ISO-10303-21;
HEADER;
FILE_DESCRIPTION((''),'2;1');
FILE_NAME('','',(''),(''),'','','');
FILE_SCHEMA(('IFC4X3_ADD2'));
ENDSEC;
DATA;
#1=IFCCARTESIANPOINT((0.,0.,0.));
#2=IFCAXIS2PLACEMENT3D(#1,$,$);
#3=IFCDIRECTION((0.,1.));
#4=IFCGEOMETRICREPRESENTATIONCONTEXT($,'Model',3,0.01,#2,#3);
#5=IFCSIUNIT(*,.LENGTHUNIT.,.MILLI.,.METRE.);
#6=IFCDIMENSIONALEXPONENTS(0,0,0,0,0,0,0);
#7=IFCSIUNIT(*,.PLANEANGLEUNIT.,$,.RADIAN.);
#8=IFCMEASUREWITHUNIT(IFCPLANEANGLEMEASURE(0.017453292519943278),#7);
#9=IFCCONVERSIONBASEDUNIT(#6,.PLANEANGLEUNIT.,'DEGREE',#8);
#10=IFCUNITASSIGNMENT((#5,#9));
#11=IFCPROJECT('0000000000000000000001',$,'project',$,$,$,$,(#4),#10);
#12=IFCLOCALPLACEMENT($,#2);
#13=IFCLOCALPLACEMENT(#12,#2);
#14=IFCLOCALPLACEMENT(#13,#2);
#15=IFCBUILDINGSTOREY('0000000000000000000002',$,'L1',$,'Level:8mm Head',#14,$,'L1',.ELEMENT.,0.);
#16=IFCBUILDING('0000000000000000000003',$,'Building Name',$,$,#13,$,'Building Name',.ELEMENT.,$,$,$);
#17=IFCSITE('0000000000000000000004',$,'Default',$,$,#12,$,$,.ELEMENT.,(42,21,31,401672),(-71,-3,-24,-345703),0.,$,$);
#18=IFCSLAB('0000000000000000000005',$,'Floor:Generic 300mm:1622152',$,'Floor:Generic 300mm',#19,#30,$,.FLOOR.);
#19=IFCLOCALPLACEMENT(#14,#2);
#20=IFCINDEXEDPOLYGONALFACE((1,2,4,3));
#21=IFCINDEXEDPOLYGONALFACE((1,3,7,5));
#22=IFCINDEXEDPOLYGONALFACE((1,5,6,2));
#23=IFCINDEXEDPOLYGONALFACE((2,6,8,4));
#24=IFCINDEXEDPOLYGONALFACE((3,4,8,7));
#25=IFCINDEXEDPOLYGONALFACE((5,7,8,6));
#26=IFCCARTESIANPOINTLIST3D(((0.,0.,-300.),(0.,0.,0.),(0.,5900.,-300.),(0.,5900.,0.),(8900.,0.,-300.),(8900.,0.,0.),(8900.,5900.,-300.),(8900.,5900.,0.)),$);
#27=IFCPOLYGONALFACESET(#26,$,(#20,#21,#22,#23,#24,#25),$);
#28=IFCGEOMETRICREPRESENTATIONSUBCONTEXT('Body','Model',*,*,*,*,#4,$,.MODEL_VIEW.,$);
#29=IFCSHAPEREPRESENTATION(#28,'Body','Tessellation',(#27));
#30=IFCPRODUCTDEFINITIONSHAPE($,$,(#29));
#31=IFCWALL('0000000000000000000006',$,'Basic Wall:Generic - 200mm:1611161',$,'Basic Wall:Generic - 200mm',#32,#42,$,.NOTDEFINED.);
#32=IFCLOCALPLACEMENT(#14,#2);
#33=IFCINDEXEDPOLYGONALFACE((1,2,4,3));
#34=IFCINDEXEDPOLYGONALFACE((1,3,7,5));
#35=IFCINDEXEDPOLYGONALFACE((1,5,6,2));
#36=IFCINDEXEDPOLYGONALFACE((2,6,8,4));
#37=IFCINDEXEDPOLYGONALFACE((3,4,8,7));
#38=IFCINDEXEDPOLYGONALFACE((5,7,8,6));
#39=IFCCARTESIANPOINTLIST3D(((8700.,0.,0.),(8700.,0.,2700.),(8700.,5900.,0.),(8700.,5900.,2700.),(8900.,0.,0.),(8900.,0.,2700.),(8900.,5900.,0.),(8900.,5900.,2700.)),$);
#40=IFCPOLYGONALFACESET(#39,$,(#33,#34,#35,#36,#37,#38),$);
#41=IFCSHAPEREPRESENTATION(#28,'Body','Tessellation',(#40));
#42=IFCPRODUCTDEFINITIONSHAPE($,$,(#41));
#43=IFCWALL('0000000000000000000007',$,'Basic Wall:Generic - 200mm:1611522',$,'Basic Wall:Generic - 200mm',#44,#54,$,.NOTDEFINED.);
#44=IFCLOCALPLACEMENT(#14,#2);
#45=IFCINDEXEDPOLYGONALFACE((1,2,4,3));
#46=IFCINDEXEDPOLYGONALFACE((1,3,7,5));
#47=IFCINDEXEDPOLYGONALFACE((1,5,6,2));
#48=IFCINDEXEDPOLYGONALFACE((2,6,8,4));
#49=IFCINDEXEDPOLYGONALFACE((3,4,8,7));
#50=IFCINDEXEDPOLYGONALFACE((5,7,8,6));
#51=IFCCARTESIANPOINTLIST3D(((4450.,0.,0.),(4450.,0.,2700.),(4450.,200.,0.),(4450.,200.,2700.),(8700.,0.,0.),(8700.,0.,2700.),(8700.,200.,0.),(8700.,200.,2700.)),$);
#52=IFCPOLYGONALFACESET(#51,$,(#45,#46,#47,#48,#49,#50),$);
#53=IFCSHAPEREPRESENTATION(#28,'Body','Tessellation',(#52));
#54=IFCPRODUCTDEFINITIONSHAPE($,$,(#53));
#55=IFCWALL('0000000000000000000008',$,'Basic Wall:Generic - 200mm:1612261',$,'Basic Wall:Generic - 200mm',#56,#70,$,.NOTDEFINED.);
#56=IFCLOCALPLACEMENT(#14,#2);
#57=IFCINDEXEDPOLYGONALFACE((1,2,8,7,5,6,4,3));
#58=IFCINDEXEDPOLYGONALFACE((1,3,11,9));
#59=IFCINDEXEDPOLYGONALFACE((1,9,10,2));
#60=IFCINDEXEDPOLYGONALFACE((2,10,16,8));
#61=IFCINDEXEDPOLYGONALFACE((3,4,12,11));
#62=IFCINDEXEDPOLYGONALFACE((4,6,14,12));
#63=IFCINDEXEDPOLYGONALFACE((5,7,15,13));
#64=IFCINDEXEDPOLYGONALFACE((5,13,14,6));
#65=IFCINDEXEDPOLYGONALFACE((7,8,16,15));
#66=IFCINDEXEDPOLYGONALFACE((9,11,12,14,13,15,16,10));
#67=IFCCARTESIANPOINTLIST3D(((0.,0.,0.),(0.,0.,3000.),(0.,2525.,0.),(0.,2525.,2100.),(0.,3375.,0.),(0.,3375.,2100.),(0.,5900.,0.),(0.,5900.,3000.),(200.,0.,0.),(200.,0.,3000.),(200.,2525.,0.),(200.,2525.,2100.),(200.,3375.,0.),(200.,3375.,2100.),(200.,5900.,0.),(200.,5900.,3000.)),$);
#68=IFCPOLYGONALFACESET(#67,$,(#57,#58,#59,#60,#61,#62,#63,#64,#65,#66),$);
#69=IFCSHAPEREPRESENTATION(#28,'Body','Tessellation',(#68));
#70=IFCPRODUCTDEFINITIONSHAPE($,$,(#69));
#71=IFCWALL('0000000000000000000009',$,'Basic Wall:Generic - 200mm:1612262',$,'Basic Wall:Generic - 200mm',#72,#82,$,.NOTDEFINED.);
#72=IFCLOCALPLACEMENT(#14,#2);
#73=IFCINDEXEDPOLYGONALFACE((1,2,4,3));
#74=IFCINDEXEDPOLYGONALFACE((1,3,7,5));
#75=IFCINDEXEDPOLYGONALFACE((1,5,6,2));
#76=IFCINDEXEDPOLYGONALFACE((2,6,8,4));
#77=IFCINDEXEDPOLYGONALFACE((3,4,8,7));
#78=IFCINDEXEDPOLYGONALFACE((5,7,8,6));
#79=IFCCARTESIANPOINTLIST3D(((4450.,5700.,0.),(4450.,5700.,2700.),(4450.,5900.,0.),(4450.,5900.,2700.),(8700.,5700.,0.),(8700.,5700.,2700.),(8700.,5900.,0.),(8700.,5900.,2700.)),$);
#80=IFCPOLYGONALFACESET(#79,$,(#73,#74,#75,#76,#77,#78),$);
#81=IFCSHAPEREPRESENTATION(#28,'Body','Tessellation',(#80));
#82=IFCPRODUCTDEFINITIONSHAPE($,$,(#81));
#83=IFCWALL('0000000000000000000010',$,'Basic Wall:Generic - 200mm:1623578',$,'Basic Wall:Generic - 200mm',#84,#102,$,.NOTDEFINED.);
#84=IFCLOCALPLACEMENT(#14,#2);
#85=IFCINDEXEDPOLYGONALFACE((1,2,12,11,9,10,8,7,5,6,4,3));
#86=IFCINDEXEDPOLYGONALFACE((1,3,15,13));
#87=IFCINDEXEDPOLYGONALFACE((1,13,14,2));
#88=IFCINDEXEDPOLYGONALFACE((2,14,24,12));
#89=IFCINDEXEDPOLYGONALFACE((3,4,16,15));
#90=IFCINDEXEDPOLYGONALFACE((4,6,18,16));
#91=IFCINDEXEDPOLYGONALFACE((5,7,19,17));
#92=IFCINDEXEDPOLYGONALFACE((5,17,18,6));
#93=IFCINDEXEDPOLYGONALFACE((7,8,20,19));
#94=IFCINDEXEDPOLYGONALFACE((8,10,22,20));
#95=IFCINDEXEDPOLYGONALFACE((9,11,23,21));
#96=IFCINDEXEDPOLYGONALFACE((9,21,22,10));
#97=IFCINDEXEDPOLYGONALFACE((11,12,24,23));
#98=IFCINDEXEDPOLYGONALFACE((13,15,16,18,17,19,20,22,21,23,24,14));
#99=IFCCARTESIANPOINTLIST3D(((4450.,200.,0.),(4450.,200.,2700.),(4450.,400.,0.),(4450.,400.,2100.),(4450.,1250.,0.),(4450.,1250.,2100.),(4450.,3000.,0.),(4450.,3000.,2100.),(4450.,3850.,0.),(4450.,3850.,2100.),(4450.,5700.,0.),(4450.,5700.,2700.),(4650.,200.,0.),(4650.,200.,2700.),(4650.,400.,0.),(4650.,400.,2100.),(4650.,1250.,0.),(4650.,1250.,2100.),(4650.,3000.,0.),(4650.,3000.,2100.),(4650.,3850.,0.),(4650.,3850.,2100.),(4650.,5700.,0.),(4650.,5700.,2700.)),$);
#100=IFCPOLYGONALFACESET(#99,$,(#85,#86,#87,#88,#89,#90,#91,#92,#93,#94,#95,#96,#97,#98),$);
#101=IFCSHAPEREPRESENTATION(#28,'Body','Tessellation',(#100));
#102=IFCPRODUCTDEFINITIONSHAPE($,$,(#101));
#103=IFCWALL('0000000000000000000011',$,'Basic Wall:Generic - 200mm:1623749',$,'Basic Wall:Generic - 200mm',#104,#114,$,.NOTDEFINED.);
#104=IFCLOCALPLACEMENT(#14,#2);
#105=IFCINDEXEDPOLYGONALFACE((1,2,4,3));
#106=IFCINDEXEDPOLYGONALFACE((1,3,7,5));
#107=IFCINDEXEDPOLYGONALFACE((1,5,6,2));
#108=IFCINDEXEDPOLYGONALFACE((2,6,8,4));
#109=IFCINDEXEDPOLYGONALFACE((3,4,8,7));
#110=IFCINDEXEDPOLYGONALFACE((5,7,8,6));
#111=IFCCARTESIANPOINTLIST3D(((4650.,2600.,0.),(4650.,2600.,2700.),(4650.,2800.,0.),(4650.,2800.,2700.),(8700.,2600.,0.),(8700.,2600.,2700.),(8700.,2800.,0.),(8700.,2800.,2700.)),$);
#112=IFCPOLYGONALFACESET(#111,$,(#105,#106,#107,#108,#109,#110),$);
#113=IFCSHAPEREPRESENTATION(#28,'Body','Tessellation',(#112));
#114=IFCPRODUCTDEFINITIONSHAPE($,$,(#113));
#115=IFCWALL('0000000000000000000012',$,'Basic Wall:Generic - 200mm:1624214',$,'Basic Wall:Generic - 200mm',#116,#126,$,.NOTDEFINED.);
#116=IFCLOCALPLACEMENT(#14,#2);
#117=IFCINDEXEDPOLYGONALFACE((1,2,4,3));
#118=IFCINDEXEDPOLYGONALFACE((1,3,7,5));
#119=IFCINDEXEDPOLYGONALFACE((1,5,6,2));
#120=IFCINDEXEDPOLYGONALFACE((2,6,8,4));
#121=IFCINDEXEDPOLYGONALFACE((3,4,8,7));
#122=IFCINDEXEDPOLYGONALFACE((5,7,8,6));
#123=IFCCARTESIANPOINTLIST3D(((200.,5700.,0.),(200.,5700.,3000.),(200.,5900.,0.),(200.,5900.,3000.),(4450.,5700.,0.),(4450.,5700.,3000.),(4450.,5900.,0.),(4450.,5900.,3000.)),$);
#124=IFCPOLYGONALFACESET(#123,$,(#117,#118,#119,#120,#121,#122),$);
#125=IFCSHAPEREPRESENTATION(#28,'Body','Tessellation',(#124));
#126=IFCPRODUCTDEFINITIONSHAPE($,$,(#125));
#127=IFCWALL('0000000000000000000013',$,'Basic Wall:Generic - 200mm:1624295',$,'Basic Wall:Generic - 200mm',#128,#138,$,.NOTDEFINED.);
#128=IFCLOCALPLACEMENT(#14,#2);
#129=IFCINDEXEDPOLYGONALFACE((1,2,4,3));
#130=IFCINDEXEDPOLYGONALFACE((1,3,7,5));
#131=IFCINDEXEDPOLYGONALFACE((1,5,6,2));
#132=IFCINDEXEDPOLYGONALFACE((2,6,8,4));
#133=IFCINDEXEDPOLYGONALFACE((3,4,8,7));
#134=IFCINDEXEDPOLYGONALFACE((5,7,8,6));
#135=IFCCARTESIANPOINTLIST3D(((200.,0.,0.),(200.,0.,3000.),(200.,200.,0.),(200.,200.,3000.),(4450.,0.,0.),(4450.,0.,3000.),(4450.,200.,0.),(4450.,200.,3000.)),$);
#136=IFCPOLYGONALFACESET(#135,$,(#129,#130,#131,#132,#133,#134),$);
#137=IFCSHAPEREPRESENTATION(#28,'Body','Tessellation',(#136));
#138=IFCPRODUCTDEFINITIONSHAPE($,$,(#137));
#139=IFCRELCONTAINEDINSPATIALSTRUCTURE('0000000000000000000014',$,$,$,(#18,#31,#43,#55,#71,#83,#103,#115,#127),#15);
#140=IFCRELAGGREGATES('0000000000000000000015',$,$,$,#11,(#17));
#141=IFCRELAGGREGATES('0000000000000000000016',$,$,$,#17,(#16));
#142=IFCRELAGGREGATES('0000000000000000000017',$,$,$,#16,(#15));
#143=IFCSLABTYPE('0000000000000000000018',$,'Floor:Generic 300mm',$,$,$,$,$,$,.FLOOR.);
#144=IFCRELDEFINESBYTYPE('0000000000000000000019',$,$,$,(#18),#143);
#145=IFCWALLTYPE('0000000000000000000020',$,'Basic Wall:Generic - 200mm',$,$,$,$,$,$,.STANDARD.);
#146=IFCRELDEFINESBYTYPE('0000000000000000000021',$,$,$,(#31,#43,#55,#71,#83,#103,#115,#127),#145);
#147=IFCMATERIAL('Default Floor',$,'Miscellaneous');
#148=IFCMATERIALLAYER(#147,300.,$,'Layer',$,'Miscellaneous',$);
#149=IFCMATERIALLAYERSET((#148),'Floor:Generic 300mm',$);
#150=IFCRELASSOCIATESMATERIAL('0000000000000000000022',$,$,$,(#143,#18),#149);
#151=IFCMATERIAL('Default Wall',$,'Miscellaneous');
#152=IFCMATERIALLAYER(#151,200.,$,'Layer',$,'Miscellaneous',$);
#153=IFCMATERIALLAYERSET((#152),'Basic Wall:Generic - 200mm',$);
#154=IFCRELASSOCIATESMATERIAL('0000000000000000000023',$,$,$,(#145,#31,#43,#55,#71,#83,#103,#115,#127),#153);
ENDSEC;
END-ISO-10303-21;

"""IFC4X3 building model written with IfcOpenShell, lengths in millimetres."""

from ifc_helpers import new_model, entity, si_unit, converted_unit, direction, frame, frame_2d, origin, origin_2d_with_axis, place, context, subcontext, project, spatial, polyline, rectangle, extrude, clip, bounded_halfspace, material, layer, layer_set, layer_usage, type_object, element, save


model = new_model("IFC4X3")

# Units and contexts
model_context = context("Model", 3, precision=0.01, world=origin(), true_north=direction((0.0, 1.0)))
body_context = subcontext(model_context, "Body", "Model", "MODEL_VIEW")
ifc_project = project(units=[si_unit("LENGTHUNIT", "METRE", prefix="MILLI"), converted_unit("PLANEANGLEUNIT", "DEGREE", entity("IfcPlaneAngleMeasure", 0.017453292519943278), si_unit("PLANEANGLEUNIT", "RADIAN"), dimensions=[0, 0, 0, 0, 0, 0, 0])], contexts=[model_context])

# Site, building, storey
site_placement = place(None, origin())
site = spatial("IfcSite", under=ifc_project, at=site_placement, Name="Default", CompositionType="ELEMENT", RefLatitude=(42, 21, 31, 401672), RefLongitude=(-71, -3, -24, -345703), RefElevation=0.0)
building_placement = place(site_placement, origin())
building = spatial("IfcBuilding", under=site, at=building_placement, Name="Building Name", LongName="Building Name", CompositionType="ELEMENT")
storey_placement = place(building_placement, origin())
storey = spatial("IfcBuildingStorey", under=building, at=storey_placement, Name="L1", ObjectType="Level:8mm Head", LongName="L1", CompositionType="ELEMENT", Elevation=0.0)

# Slab
ifc_material_1 = material(Name="Default Floor", Category="Miscellaneous")
ifc_layer_1 = layer(ifc_material_1, 300.0, Name="Layer", Category="Miscellaneous")
ifc_layer_set_1 = layer_set([ifc_layer_1], Name="Floor:Generic 300mm")
ifc_layer_usage = layer_usage(ifc_layer_set_1, "AXIS3", "POSITIVE", 0.0)
slab_type = type_object("IfcSlabType", Name="Floor:Generic 300mm", PredefinedType="FLOOR", material=ifc_layer_set_1)
slab_placement = place(storey_placement, origin())
element("IfcSlab", 1, at=slab_placement, inside=storey, type_object=slab_type, material=ifc_layer_usage, Name="Floor:Generic 300mm:1622152", ObjectType="Floor:Generic 300mm", PredefinedType="FLOOR", context=body_context, shape_type="SweptSolid", body=[
    extrude(rectangle(XDim=5900.0, YDim=8900.0, at=origin_2d_with_axis()), frame((4450.0, 2950.0, 0.0), z_axis=(0.0, 0.0, -1.0), x_axis=(0.0, 1.0, 0.0)), (0.0, 0.0, 1.0), 300.0),
])

# Walls
ifc_material_2 = material(Name="Default Wall", Category="Miscellaneous")
ifc_layer_2 = layer(ifc_material_2, 200.0, Name="Layer", Category="Miscellaneous")
ifc_layer_set_2 = layer_set([ifc_layer_2], Name="Basic Wall:Generic - 200mm")
wall_type = type_object("IfcWallType", Name="Basic Wall:Generic - 200mm", PredefinedType="STANDARD", material=ifc_layer_set_2)
wall_1_placement = place(storey_placement, frame((8800.0, 0.0, 0.0), z_axis=(0.0, 0.0, 1.0), x_axis=(0.0, 1.0, 0.0)))
element("IfcWall", 2, at=wall_1_placement, inside=storey, type_object=wall_type, material=ifc_layer_set_2, Name="Basic Wall:Generic - 200mm:1611161", ObjectType="Basic Wall:Generic - 200mm", PredefinedType="NOTDEFINED", context=body_context, shape_type="Clipping", body=[
    clip(extrude(rectangle(XDim=5900.0, YDim=200.0, at=frame_2d((2950.0, 0.0), x_axis=(-1.0, 0.0))), origin(), (0.0, 0.0, 1.0), 2700.0), bounded_halfspace(frame((0.0, -100.0, 2700.0), z_axis=(0.0, 0.0, -1.0), x_axis=(0.0, 1.0, 0.0)), True, frame((0.0, -100.0, 2700.0)), polyline([(0.0, 0.0), (5900.0, 0.0), (5900.0, 200.0), (5700.0, 200.0), (2800.0, 200.0), (2600.0, 200.0), (200.0, 200.0), (0.0, 200.0), (0.0, 0.0)]))),
])
wall_2_placement = place(storey_placement, frame((4450.0, 100.0, 0.0)))
element("IfcWall", 3, at=wall_2_placement, inside=storey, type_object=wall_type, material=ifc_layer_set_2, Name="Basic Wall:Generic - 200mm:1611522", ObjectType="Basic Wall:Generic - 200mm", PredefinedType="NOTDEFINED", context=body_context, shape_type="Clipping", body=[
    clip(extrude(rectangle(XDim=4250.0, YDim=200.0, at=frame_2d((2125.0, 0.0), x_axis=(-1.0, 0.0))), origin(), (0.0, 0.0, 1.0), 2700.0), bounded_halfspace(frame((0.0, -100.0, 2700.0), z_axis=(0.0, 0.0, -1.0), x_axis=(-1.0, 0.0, 0.0)), True, frame((0.0, -100.0, 2700.0)), polyline([(0.0, 0.0), (4250.0, 0.0), (4250.0, 200.0), (200.0, 200.0), (0.0, 200.0), (0.0, 0.0)]))),
])

# Wall, opening
wall_3_placement = place(storey_placement, frame((100.0, 5900.0, 0.0), z_axis=(0.0, 0.0, 1.0), x_axis=(0.0, -1.0, 0.0)))
wall_3 = element("IfcWall", 4, at=wall_3_placement, inside=storey, type_object=wall_type, material=ifc_layer_set_2, Name="Basic Wall:Generic - 200mm:1612261", ObjectType="Basic Wall:Generic - 200mm", PredefinedType="NOTDEFINED", context=body_context, shape_type="SweptSolid", body=[
    extrude(rectangle(XDim=5900.0, YDim=200.0, at=frame_2d((2950.0, 0.0), x_axis=(-1.0, 0.0))), origin(), (0.0, 0.0, 1.0), 3000.0),
])
opening_1_placement = place(wall_3_placement, frame((2525.0, -100.0, 0.0)))
element("IfcOpeningElement", 5, at=opening_1_placement, cuts=wall_3, PredefinedType="OPENING", context=body_context, shape_type="SweptSolid", body=[
    extrude(rectangle(XDim=2100.0, YDim=850.0, at=frame_2d((1050.0, 425.0), x_axis=(1.0, 0.0))), frame((0.0, 0.0, 0.0), z_axis=(0.0, 1.0, 0.0), x_axis=(0.0, 0.0, 1.0)), (0.0, 0.0, 1.0), 200.0),
])

# Wall
wall_4_placement = place(storey_placement, frame((8700.0, 5800.0, 0.0), z_axis=(0.0, 0.0, 1.0), x_axis=(-1.0, 0.0, 0.0)))
element("IfcWall", 6, at=wall_4_placement, inside=storey, type_object=wall_type, material=ifc_layer_set_2, Name="Basic Wall:Generic - 200mm:1612262", ObjectType="Basic Wall:Generic - 200mm", PredefinedType="NOTDEFINED", context=body_context, shape_type="Clipping", body=[
    clip(extrude(rectangle(XDim=4250.0, YDim=200.0, at=frame_2d((2125.0, 0.0), x_axis=(-1.0, 0.0))), origin(), (0.0, 0.0, 1.0), 2700.0), bounded_halfspace(frame((0.0, -100.0, 2700.0), z_axis=(0.0, 0.0, -1.0), x_axis=(1.0, 0.0, 0.0)), True, frame((0.0, -100.0, 2700.0)), polyline([(0.0, 0.0), (4250.0, 0.0), (4250.0, 200.0), (4050.0, 200.0), (0.0, 200.0), (0.0, 0.0)]))),
])

# Wall, openings
wall_5_placement = place(storey_placement, frame((4550.0, 5700.0, 0.0), z_axis=(0.0, 0.0, 1.0), x_axis=(0.0, -1.0, 0.0)))
wall_5 = element("IfcWall", 7, at=wall_5_placement, inside=storey, type_object=wall_type, material=ifc_layer_set_2, Name="Basic Wall:Generic - 200mm:1623578", ObjectType="Basic Wall:Generic - 200mm", PredefinedType="NOTDEFINED", context=body_context, shape_type="Clipping", body=[
    clip(extrude(rectangle(XDim=5500.0, YDim=200.0, at=frame_2d((2750.0, 0.0), x_axis=(1.0, 0.0))), origin(), (0.0, 0.0, 1.0), 2700.0), bounded_halfspace(frame((0.0, -100.0, 2700.0), z_axis=(0.0, 0.0, -1.0), x_axis=(0.0, -1.0, 0.0)), True, frame((0.0, -100.0, 2700.0)), polyline([(0.0, 0.0), (5500.0, 0.0), (5500.0, 200.0), (3100.0, 200.0), (2900.0, 200.0), (0.0, 200.0), (0.0, 0.0)]))),
])
opening_2_placement = place(wall_5_placement, frame((1850.0, -100.0, 0.0)))
element("IfcOpeningElement", 8, at=opening_2_placement, cuts=wall_5, PredefinedType="OPENING", context=body_context, shape_type="SweptSolid", body=[
    extrude(rectangle(XDim=2100.0, YDim=850.0, at=frame_2d((1050.0, 425.0), x_axis=(1.0, 0.0))), frame((0.0, 0.0, 0.0), z_axis=(0.0, 1.0, 0.0), x_axis=(0.0, 0.0, 1.0)), (0.0, 0.0, 1.0), 200.0),
])
opening_3_placement = place(wall_5_placement, frame((4450.0, -100.0, 0.0)))
element("IfcOpeningElement", 9, at=opening_3_placement, cuts=wall_5, PredefinedType="OPENING", context=body_context, shape_type="SweptSolid", body=[
    extrude(rectangle(XDim=2100.0, YDim=850.0, at=frame_2d((1050.0, 425.0), x_axis=(1.0, 0.0))), frame((0.0, 0.0, 0.0), z_axis=(0.0, 1.0, 0.0), x_axis=(0.0, 0.0, 1.0)), (0.0, 0.0, 1.0), 200.0),
])

# Walls
wall_6_placement = place(storey_placement, frame((4650.0, 2700.0, 0.0)))
element("IfcWall", 10, at=wall_6_placement, inside=storey, type_object=wall_type, material=ifc_layer_set_2, Name="Basic Wall:Generic - 200mm:1623749", ObjectType="Basic Wall:Generic - 200mm", PredefinedType="NOTDEFINED", context=body_context, shape_type="Clipping", body=[
    clip(extrude(rectangle(XDim=4050.0, YDim=200.0, at=frame_2d((2025.0, 0.0), x_axis=(-1.0, 0.0))), origin(), (0.0, 0.0, 1.0), 2700.0), bounded_halfspace(frame((0.0, -100.0, 2700.0), z_axis=(0.0, 0.0, -1.0), x_axis=(-1.0, 0.0, 0.0)), True, frame((0.0, -100.0, 2700.0)), polyline([(0.0, 0.0), (4050.0, 0.0), (4050.0, 200.0), (0.0, 200.0), (0.0, 0.0)]))),
])
wall_7_placement = place(storey_placement, frame((4450.0, 5800.0, 0.0), z_axis=(0.0, 0.0, 1.0), x_axis=(-1.0, 0.0, 0.0)))
element("IfcWall", 11, at=wall_7_placement, inside=storey, type_object=wall_type, material=ifc_layer_set_2, Name="Basic Wall:Generic - 200mm:1624214", ObjectType="Basic Wall:Generic - 200mm", PredefinedType="NOTDEFINED", context=body_context, shape_type="SweptSolid", body=[
    extrude(rectangle(XDim=4250.0, YDim=200.0, at=frame_2d((2125.0, 0.0), x_axis=(-1.0, 0.0))), origin(), (0.0, 0.0, 1.0), 3000.0),
])
wall_8_placement = place(storey_placement, frame((200.0, 100.0, 0.0)))
element("IfcWall", 12, at=wall_8_placement, inside=storey, type_object=wall_type, material=ifc_layer_set_2, Name="Basic Wall:Generic - 200mm:1624295", ObjectType="Basic Wall:Generic - 200mm", PredefinedType="NOTDEFINED", context=body_context, shape_type="SweptSolid", body=[
    extrude(rectangle(XDim=4250.0, YDim=200.0, at=frame_2d((2125.0, 0.0), x_axis=(-1.0, 0.0))), origin(), (0.0, 0.0, 1.0), 3000.0),
])

save(model, "model.ifc")
